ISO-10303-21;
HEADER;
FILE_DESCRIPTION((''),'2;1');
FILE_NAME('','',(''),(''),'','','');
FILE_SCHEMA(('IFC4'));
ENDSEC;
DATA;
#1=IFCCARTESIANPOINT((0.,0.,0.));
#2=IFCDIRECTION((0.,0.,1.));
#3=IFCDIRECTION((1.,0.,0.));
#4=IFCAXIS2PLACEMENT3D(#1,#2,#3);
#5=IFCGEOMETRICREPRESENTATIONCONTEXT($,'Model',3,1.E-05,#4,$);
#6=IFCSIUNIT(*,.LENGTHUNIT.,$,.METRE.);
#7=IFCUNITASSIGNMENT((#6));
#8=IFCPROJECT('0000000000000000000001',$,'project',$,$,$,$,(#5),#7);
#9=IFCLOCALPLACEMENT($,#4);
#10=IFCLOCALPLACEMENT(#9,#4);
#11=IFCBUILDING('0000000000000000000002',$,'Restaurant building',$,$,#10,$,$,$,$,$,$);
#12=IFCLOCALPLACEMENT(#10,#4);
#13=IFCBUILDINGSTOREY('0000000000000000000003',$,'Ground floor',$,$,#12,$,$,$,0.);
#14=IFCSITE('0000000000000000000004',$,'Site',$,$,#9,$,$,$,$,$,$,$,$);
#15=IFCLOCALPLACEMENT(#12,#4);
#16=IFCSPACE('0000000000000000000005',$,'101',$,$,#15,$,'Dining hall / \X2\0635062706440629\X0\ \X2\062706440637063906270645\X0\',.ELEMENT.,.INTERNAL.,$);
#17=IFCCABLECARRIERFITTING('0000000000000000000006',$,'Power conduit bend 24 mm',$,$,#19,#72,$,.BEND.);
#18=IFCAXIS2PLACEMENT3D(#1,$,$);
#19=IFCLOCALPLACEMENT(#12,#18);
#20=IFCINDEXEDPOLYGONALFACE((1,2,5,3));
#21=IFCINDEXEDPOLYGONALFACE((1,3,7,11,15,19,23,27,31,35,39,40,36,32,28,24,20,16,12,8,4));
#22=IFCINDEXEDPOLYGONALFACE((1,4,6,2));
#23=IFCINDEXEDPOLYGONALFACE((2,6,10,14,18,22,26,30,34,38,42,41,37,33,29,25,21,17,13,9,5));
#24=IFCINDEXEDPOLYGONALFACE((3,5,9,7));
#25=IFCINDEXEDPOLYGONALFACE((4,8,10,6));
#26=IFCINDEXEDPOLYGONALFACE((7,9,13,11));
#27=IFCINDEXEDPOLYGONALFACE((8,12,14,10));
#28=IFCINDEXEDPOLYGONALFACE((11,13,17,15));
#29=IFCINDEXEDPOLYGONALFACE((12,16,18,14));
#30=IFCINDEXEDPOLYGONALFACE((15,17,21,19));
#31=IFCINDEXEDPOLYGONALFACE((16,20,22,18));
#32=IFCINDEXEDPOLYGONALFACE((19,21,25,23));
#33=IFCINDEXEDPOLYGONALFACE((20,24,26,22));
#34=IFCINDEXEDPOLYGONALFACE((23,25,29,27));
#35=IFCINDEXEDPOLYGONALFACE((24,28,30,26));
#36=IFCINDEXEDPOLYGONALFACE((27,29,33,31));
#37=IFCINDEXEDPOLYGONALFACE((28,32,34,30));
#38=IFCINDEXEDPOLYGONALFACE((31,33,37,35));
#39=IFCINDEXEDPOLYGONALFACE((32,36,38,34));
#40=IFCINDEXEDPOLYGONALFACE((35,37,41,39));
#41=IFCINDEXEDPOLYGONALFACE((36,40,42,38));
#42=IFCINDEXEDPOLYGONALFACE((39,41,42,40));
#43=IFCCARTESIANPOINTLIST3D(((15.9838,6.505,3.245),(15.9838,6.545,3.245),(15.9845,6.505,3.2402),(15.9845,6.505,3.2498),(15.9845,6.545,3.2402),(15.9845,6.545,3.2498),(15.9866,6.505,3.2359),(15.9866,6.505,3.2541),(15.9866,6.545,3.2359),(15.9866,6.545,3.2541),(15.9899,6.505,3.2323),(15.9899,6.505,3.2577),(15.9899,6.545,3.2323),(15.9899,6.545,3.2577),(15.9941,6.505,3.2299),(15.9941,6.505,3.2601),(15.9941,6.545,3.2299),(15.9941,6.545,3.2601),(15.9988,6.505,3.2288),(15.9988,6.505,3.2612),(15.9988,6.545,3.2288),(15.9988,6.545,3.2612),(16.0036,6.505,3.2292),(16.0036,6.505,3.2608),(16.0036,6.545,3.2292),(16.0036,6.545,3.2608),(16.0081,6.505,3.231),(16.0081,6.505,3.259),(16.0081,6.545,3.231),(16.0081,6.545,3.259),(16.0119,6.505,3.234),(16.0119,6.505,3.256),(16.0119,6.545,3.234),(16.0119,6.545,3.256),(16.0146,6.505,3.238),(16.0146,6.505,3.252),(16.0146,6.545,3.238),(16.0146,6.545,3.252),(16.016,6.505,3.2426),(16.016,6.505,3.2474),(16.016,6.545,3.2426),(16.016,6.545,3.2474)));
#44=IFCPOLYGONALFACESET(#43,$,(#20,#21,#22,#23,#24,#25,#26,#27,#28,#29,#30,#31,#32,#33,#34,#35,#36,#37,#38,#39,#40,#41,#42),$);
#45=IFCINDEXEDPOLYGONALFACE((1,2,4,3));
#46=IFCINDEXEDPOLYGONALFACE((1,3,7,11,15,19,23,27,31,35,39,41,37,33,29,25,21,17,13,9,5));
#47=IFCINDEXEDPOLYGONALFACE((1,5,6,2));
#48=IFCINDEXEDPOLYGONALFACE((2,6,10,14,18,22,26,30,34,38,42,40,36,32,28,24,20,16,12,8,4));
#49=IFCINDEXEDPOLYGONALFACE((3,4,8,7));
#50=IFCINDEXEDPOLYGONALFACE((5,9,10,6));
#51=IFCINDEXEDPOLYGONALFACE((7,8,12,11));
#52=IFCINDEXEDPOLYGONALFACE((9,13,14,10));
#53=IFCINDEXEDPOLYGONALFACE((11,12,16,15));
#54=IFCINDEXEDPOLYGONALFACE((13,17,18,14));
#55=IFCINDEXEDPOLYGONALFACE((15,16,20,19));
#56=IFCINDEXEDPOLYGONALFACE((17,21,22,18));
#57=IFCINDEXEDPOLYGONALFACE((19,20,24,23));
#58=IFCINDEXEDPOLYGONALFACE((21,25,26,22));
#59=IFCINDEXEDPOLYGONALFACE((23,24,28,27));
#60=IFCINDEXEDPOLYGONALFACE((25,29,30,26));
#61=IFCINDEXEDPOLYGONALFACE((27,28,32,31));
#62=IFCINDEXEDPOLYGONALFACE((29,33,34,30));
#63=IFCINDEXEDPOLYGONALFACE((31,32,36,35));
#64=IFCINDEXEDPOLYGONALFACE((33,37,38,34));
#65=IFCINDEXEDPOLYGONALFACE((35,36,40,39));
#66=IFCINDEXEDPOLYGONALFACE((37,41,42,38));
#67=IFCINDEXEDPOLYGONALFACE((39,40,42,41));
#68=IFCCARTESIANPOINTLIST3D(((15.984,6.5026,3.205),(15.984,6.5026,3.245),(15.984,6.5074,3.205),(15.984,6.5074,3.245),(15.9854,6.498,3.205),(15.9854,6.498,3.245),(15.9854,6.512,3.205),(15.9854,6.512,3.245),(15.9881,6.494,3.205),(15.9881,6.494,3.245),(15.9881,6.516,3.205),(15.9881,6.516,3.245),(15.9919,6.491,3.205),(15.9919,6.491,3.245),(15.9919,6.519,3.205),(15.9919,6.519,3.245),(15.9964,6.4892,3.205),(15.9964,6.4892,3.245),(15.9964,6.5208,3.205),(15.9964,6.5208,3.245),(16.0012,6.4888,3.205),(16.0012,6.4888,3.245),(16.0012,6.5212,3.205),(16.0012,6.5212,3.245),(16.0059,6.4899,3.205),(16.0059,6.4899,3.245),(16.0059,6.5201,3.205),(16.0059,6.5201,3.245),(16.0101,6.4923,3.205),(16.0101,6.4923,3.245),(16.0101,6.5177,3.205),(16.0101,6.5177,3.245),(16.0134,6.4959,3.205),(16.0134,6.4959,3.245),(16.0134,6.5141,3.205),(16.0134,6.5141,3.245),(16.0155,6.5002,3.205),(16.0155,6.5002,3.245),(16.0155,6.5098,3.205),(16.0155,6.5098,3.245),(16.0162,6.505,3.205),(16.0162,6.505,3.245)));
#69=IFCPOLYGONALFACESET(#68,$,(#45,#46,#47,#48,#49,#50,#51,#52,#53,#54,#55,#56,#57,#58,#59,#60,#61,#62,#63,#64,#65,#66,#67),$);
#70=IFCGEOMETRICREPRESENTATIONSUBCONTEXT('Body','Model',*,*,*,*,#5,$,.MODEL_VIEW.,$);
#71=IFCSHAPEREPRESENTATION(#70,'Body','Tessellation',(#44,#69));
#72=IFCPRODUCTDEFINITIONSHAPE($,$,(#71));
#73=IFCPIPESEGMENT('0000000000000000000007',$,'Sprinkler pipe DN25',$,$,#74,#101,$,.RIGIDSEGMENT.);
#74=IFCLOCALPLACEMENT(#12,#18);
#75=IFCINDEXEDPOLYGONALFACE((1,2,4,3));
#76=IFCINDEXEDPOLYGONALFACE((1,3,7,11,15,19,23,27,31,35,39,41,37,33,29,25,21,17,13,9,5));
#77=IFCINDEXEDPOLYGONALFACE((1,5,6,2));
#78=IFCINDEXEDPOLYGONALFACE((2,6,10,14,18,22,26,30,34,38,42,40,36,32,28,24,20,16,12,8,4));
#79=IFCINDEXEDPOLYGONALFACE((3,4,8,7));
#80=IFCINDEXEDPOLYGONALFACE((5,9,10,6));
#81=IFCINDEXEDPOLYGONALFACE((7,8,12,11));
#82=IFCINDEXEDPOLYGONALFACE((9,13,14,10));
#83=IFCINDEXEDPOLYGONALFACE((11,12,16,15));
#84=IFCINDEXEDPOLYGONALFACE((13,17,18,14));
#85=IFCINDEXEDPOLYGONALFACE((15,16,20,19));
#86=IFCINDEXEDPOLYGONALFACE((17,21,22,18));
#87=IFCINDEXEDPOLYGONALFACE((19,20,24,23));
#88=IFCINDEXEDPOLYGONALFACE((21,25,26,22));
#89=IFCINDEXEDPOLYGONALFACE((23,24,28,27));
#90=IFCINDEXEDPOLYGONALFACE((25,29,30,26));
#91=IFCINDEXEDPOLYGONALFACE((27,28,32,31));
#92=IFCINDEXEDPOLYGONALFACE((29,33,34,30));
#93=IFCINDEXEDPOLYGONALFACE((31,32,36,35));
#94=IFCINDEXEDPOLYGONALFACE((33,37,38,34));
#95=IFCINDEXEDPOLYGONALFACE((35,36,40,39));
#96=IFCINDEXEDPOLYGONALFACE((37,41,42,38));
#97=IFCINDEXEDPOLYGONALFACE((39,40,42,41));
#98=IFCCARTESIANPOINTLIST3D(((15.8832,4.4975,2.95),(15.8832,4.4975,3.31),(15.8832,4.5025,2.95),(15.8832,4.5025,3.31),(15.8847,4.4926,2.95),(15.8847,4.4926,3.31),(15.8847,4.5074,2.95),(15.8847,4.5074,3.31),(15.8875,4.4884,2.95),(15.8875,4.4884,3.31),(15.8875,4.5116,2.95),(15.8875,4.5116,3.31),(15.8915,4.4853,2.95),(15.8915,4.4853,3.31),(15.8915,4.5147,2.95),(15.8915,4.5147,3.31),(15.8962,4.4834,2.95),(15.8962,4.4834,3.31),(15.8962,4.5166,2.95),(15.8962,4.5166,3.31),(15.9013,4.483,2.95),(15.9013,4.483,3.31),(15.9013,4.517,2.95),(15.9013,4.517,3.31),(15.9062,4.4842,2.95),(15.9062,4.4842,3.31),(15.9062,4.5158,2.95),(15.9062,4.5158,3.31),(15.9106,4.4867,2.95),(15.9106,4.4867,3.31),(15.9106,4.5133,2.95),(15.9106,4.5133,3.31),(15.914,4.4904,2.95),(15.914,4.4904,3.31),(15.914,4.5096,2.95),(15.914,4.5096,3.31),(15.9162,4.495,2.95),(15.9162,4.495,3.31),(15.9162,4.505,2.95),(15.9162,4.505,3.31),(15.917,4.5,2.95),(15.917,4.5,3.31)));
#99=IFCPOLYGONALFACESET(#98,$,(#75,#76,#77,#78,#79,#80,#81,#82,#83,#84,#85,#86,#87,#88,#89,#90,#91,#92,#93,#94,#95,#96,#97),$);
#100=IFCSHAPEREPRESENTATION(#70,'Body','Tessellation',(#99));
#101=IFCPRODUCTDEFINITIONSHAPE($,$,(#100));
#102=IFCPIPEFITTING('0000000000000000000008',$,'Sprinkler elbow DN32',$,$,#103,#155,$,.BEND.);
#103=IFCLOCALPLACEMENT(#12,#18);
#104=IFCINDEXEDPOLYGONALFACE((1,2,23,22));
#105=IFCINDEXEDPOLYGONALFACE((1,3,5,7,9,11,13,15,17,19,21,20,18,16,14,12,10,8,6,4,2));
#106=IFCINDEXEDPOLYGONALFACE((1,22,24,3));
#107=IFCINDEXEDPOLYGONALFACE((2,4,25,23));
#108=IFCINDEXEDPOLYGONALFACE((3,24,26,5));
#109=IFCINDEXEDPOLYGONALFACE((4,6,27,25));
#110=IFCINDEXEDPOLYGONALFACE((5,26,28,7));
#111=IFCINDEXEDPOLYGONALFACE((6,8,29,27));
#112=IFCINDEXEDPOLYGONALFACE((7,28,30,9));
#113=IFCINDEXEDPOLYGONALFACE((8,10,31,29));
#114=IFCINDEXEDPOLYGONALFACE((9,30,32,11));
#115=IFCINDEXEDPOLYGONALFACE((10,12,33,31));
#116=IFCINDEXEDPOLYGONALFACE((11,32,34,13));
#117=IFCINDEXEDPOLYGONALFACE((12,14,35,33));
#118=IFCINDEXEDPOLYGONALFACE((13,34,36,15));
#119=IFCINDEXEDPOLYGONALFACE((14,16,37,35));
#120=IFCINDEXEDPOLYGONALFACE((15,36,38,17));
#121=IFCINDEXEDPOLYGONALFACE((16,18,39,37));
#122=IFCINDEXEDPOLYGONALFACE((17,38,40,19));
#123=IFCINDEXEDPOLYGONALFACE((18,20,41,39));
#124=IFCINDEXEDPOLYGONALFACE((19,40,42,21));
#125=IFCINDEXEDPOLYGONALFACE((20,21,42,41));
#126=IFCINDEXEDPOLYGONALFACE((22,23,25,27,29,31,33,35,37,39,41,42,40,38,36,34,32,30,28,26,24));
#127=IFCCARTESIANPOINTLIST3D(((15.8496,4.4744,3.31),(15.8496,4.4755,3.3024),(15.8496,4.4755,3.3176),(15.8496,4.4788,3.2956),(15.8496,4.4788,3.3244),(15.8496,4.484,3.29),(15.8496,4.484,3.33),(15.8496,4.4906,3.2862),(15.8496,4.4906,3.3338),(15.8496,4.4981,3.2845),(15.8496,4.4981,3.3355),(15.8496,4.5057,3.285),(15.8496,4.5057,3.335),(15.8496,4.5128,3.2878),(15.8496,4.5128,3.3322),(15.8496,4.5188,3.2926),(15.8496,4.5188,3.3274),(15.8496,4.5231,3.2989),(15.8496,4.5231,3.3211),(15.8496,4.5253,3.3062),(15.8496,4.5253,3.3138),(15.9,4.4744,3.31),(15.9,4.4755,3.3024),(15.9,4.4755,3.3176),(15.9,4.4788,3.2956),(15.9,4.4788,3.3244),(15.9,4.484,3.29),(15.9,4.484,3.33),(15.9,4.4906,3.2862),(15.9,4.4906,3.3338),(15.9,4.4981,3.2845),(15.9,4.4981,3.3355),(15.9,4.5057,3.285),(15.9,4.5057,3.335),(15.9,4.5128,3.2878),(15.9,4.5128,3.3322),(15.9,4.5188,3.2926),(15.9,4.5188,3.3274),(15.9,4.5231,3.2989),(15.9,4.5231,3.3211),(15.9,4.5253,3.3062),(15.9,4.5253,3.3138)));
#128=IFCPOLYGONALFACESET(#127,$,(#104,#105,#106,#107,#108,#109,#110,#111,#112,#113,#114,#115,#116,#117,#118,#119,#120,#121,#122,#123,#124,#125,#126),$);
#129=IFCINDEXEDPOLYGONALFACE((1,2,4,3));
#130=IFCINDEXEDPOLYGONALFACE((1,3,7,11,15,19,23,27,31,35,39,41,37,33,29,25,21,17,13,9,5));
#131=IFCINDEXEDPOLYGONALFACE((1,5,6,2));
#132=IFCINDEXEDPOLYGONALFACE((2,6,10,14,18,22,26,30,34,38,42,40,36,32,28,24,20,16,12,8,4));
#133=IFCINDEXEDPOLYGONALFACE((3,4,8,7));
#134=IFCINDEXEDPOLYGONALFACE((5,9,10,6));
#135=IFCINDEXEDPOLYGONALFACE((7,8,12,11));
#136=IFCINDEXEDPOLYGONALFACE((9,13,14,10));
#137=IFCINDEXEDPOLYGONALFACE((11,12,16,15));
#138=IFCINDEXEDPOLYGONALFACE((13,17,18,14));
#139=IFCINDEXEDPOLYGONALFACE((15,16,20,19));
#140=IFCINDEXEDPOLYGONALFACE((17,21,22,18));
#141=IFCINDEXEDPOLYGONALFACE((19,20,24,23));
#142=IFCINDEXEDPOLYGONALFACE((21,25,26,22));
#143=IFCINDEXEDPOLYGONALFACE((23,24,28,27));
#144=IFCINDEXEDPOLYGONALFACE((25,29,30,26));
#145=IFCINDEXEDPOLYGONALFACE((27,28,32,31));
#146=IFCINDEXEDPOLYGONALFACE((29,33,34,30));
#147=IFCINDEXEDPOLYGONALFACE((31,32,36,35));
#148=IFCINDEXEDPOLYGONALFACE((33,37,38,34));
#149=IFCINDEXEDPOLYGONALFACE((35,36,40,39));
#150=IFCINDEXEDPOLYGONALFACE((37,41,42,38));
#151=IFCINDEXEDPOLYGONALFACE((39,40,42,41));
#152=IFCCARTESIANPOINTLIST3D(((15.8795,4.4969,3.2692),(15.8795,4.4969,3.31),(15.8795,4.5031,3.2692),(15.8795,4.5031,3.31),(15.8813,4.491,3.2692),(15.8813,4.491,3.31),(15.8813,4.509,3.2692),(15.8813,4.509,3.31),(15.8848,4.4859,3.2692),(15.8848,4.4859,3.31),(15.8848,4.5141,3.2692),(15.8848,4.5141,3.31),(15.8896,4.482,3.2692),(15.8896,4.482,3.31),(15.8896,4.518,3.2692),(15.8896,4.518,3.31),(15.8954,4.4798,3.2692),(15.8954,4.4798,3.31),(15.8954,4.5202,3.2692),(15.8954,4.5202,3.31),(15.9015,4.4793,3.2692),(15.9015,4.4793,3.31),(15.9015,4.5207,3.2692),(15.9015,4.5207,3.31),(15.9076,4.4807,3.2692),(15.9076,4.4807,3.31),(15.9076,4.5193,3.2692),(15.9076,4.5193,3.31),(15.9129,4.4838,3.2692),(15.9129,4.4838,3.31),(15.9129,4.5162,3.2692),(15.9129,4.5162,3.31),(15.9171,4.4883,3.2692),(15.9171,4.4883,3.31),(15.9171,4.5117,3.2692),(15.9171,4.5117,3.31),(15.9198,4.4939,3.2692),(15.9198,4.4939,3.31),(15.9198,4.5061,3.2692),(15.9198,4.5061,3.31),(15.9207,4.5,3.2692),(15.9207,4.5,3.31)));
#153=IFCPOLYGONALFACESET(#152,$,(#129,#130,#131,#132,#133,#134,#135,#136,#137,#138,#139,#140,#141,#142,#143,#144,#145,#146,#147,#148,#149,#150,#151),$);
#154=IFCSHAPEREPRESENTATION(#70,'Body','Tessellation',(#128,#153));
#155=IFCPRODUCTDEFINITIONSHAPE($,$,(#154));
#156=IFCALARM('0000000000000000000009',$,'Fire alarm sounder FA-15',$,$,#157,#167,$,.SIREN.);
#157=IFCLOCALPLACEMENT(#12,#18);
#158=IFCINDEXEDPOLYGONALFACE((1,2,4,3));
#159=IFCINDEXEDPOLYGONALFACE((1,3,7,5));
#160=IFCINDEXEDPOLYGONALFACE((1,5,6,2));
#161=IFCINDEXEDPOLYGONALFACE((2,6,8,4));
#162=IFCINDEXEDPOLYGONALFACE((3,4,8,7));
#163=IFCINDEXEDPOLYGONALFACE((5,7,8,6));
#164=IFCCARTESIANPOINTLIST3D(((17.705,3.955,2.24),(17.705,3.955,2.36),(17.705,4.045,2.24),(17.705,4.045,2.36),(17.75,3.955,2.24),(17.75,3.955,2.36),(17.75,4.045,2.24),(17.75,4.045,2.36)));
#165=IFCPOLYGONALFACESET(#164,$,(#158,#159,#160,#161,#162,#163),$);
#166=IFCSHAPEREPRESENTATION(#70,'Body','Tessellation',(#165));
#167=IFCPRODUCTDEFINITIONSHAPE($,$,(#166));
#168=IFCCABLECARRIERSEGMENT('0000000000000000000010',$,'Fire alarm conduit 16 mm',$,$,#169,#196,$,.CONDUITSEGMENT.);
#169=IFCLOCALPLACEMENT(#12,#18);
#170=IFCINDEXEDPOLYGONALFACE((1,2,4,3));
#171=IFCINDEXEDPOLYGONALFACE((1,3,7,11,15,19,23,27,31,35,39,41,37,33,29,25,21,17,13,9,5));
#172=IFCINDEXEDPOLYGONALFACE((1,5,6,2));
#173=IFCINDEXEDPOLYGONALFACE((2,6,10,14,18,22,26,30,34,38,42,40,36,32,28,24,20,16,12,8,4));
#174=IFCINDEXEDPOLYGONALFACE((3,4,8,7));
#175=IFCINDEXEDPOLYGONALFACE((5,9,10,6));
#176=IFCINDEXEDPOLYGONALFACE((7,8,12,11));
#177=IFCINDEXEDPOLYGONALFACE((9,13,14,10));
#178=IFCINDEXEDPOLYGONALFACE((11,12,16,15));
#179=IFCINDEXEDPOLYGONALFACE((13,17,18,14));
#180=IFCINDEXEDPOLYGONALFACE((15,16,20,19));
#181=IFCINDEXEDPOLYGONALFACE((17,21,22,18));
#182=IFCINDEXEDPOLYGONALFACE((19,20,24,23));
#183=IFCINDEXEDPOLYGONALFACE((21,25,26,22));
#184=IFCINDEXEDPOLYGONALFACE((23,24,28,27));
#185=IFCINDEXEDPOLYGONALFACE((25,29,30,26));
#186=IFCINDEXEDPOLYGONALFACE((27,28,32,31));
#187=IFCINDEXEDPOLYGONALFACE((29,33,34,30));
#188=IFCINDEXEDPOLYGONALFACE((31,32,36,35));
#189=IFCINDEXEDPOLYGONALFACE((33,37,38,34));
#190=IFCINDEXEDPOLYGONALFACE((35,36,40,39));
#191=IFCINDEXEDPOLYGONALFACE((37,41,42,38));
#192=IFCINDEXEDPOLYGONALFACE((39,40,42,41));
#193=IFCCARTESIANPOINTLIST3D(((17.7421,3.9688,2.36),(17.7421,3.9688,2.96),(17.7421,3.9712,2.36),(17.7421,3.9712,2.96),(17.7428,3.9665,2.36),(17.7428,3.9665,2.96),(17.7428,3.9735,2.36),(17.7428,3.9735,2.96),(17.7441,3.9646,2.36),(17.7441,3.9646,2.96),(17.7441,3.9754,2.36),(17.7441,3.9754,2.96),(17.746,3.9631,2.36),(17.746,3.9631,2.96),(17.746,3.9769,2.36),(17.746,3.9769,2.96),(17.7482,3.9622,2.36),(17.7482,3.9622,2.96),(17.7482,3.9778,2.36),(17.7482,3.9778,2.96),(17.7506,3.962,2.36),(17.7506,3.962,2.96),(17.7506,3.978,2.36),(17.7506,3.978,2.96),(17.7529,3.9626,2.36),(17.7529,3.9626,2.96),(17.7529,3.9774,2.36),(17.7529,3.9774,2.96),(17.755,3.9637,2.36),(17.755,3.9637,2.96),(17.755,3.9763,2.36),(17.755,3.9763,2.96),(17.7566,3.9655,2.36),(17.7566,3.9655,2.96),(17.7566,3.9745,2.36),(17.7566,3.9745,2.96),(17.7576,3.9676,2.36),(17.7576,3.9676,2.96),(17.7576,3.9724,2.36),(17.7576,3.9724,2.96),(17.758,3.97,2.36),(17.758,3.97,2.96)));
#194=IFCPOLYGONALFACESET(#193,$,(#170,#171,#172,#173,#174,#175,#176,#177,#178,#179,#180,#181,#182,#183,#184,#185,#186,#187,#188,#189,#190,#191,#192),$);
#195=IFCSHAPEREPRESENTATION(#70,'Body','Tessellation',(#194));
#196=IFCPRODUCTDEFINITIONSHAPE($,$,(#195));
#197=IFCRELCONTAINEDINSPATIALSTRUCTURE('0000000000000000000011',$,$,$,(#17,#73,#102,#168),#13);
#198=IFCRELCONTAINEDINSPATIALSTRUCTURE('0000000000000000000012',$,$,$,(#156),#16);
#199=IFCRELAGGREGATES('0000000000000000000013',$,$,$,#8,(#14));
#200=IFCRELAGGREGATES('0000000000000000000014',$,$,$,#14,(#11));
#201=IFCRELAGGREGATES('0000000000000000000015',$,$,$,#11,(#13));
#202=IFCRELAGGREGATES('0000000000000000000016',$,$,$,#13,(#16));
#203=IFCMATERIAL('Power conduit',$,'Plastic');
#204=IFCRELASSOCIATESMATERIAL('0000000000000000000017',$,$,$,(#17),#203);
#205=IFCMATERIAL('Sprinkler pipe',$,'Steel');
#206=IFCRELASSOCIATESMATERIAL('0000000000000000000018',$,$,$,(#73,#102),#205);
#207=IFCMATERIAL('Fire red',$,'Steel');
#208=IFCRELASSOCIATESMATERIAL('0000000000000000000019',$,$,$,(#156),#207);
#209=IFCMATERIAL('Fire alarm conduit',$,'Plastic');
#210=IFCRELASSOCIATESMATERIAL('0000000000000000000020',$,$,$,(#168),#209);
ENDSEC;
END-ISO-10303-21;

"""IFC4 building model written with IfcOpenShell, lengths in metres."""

from ifc_helpers import new_model, si_unit, frame, origin_with_axes, origin_2d, place, context, subcontext, project, spatial, rectangle, circle, extrude, material, element, save


model = new_model("IFC4")

# Units and contexts
model_context = context("Model", 3, precision=1e-05, world=origin_with_axes())
body_context = subcontext(model_context, "Body", "Model", "MODEL_VIEW")
ifc_project = project(units=[si_unit("LENGTHUNIT", "METRE")], contexts=[model_context])

# Site, building, storey
site_placement = place(None, origin_with_axes())
site = spatial("IfcSite", under=ifc_project, at=site_placement, Name="Site")
building_placement = place(site_placement, origin_with_axes())
building = spatial("IfcBuilding", under=site, at=building_placement, Name="Restaurant building")
storey_placement = place(building_placement, origin_with_axes())
storey = spatial("IfcBuildingStorey", under=building, at=storey_placement, Name="Ground floor", Elevation=0.0)

# Shared definitions
space_1_placement = place(storey_placement, origin_with_axes())
space_1 = spatial("IfcSpace", under=storey, at=space_1_placement, Name="101", LongName="Dining hall / صالة الطعام", CompositionType="ELEMENT", PredefinedType="INTERNAL")

# Shared definitions
ifc_material_1 = material(Name="Power conduit", Category="Plastic")

# Cable carrier fitting
for number, where, name in (
    (1, (16.0, 6.505, 3.245), "Power conduit bend 24 mm"),
):
    element("IfcCableCarrierFitting", number, at=place(storey_placement, frame(where)), inside=storey, material=ifc_material_1, Name=name, PredefinedType="BEND", context=body_context, shape_type="SweptSolid", body=[
        extrude(circle(Radius=0.0162, at=origin_2d()), frame((0.0, 0.0, 0.0), z_axis=(0.0, 1.0, 0.0), x_axis=(-1.0, 0.0, 0.0)), (0.0, 0.0, 1.0), 0.04),
        extrude(circle(Radius=0.0162, at=origin_2d()), frame((0.0, 0.0, 0.0), z_axis=(0.0, 0.0, -1.0), x_axis=(1.0, 0.0, 0.0)), (0.0, 0.0, 1.0), 0.04),
    ])

# Pipe segment
ifc_material_2 = material(Name="Sprinkler pipe", Category="Steel")
pipe_segment_placement = place(storey_placement, frame((15.9, 4.5, 3.31)))
element("IfcPipeSegment", 2, at=pipe_segment_placement, inside=storey, material=ifc_material_2, Name="Sprinkler pipe DN25", PredefinedType="RIGIDSEGMENT", context=body_context, shape_type="SweptSolid", body=[
    extrude(circle(Radius=0.017, at=origin_2d()), frame((0.0, 0.0, 0.0), z_axis=(0.0, 0.0, -1.0), x_axis=(1.0, 0.0, 0.0)), (0.0, 0.0, 1.0), 0.36),
])

# Pipe fitting
pipe_fitting_placement = place(storey_placement, frame((15.9, 4.5, 3.31)))
element("IfcPipeFitting", 3, at=pipe_fitting_placement, inside=storey, material=ifc_material_2, Name="Sprinkler elbow DN32", PredefinedType="BEND", context=body_context, shape_type="SweptSolid", body=[
    extrude(circle(Radius=0.0256, at=origin_2d()), frame((0.0, 0.0, 0.0), z_axis=(-1.0, 0.0, 0.0), x_axis=(0.0, -1.0, 0.0)), (0.0, 0.0, 1.0), 0.0504),
    extrude(circle(Radius=0.0207, at=origin_2d()), frame((0.0, 0.0, 0.0), z_axis=(0.0, 0.0, -1.0), x_axis=(1.0, 0.0, 0.0)), (0.0, 0.0, 1.0), 0.0408),
])

# Alarm
ifc_material_3 = material(Name="Fire red", Category="Steel")
alarm_placement = place(storey_placement, frame((17.75, 4.0, 2.3)))
element("IfcAlarm", 4, at=alarm_placement, inside=space_1, material=ifc_material_3, Name="Fire alarm sounder FA-15", PredefinedType="SIREN", context=body_context, shape_type="SweptSolid", body=[
    extrude(rectangle(XDim=0.045, YDim=0.09, at=origin_2d()), frame((-0.0225, 0.0, -0.06)), (0.0, 0.0, 1.0), 0.12),
])

# Cable carrier segment
ifc_material_4 = material(Name="Fire alarm conduit", Category="Plastic")
cable_carrier_segment_1_placement = place(storey_placement, frame((17.75, 3.97, 2.96)))
element("IfcCableCarrierSegment", 5, at=cable_carrier_segment_1_placement, inside=storey, material=ifc_material_4, Name="Fire alarm conduit 16 mm", PredefinedType="CONDUITSEGMENT", context=body_context, shape_type="SweptSolid", body=[
    extrude(circle(Radius=0.008, at=origin_2d()), frame((0.0, 0.0, 0.0), z_axis=(0.0, 0.0, -1.0), x_axis=(1.0, 0.0, 0.0)), (0.0, 0.0, 1.0), 0.6),
])

save(model, "model.ifc")
